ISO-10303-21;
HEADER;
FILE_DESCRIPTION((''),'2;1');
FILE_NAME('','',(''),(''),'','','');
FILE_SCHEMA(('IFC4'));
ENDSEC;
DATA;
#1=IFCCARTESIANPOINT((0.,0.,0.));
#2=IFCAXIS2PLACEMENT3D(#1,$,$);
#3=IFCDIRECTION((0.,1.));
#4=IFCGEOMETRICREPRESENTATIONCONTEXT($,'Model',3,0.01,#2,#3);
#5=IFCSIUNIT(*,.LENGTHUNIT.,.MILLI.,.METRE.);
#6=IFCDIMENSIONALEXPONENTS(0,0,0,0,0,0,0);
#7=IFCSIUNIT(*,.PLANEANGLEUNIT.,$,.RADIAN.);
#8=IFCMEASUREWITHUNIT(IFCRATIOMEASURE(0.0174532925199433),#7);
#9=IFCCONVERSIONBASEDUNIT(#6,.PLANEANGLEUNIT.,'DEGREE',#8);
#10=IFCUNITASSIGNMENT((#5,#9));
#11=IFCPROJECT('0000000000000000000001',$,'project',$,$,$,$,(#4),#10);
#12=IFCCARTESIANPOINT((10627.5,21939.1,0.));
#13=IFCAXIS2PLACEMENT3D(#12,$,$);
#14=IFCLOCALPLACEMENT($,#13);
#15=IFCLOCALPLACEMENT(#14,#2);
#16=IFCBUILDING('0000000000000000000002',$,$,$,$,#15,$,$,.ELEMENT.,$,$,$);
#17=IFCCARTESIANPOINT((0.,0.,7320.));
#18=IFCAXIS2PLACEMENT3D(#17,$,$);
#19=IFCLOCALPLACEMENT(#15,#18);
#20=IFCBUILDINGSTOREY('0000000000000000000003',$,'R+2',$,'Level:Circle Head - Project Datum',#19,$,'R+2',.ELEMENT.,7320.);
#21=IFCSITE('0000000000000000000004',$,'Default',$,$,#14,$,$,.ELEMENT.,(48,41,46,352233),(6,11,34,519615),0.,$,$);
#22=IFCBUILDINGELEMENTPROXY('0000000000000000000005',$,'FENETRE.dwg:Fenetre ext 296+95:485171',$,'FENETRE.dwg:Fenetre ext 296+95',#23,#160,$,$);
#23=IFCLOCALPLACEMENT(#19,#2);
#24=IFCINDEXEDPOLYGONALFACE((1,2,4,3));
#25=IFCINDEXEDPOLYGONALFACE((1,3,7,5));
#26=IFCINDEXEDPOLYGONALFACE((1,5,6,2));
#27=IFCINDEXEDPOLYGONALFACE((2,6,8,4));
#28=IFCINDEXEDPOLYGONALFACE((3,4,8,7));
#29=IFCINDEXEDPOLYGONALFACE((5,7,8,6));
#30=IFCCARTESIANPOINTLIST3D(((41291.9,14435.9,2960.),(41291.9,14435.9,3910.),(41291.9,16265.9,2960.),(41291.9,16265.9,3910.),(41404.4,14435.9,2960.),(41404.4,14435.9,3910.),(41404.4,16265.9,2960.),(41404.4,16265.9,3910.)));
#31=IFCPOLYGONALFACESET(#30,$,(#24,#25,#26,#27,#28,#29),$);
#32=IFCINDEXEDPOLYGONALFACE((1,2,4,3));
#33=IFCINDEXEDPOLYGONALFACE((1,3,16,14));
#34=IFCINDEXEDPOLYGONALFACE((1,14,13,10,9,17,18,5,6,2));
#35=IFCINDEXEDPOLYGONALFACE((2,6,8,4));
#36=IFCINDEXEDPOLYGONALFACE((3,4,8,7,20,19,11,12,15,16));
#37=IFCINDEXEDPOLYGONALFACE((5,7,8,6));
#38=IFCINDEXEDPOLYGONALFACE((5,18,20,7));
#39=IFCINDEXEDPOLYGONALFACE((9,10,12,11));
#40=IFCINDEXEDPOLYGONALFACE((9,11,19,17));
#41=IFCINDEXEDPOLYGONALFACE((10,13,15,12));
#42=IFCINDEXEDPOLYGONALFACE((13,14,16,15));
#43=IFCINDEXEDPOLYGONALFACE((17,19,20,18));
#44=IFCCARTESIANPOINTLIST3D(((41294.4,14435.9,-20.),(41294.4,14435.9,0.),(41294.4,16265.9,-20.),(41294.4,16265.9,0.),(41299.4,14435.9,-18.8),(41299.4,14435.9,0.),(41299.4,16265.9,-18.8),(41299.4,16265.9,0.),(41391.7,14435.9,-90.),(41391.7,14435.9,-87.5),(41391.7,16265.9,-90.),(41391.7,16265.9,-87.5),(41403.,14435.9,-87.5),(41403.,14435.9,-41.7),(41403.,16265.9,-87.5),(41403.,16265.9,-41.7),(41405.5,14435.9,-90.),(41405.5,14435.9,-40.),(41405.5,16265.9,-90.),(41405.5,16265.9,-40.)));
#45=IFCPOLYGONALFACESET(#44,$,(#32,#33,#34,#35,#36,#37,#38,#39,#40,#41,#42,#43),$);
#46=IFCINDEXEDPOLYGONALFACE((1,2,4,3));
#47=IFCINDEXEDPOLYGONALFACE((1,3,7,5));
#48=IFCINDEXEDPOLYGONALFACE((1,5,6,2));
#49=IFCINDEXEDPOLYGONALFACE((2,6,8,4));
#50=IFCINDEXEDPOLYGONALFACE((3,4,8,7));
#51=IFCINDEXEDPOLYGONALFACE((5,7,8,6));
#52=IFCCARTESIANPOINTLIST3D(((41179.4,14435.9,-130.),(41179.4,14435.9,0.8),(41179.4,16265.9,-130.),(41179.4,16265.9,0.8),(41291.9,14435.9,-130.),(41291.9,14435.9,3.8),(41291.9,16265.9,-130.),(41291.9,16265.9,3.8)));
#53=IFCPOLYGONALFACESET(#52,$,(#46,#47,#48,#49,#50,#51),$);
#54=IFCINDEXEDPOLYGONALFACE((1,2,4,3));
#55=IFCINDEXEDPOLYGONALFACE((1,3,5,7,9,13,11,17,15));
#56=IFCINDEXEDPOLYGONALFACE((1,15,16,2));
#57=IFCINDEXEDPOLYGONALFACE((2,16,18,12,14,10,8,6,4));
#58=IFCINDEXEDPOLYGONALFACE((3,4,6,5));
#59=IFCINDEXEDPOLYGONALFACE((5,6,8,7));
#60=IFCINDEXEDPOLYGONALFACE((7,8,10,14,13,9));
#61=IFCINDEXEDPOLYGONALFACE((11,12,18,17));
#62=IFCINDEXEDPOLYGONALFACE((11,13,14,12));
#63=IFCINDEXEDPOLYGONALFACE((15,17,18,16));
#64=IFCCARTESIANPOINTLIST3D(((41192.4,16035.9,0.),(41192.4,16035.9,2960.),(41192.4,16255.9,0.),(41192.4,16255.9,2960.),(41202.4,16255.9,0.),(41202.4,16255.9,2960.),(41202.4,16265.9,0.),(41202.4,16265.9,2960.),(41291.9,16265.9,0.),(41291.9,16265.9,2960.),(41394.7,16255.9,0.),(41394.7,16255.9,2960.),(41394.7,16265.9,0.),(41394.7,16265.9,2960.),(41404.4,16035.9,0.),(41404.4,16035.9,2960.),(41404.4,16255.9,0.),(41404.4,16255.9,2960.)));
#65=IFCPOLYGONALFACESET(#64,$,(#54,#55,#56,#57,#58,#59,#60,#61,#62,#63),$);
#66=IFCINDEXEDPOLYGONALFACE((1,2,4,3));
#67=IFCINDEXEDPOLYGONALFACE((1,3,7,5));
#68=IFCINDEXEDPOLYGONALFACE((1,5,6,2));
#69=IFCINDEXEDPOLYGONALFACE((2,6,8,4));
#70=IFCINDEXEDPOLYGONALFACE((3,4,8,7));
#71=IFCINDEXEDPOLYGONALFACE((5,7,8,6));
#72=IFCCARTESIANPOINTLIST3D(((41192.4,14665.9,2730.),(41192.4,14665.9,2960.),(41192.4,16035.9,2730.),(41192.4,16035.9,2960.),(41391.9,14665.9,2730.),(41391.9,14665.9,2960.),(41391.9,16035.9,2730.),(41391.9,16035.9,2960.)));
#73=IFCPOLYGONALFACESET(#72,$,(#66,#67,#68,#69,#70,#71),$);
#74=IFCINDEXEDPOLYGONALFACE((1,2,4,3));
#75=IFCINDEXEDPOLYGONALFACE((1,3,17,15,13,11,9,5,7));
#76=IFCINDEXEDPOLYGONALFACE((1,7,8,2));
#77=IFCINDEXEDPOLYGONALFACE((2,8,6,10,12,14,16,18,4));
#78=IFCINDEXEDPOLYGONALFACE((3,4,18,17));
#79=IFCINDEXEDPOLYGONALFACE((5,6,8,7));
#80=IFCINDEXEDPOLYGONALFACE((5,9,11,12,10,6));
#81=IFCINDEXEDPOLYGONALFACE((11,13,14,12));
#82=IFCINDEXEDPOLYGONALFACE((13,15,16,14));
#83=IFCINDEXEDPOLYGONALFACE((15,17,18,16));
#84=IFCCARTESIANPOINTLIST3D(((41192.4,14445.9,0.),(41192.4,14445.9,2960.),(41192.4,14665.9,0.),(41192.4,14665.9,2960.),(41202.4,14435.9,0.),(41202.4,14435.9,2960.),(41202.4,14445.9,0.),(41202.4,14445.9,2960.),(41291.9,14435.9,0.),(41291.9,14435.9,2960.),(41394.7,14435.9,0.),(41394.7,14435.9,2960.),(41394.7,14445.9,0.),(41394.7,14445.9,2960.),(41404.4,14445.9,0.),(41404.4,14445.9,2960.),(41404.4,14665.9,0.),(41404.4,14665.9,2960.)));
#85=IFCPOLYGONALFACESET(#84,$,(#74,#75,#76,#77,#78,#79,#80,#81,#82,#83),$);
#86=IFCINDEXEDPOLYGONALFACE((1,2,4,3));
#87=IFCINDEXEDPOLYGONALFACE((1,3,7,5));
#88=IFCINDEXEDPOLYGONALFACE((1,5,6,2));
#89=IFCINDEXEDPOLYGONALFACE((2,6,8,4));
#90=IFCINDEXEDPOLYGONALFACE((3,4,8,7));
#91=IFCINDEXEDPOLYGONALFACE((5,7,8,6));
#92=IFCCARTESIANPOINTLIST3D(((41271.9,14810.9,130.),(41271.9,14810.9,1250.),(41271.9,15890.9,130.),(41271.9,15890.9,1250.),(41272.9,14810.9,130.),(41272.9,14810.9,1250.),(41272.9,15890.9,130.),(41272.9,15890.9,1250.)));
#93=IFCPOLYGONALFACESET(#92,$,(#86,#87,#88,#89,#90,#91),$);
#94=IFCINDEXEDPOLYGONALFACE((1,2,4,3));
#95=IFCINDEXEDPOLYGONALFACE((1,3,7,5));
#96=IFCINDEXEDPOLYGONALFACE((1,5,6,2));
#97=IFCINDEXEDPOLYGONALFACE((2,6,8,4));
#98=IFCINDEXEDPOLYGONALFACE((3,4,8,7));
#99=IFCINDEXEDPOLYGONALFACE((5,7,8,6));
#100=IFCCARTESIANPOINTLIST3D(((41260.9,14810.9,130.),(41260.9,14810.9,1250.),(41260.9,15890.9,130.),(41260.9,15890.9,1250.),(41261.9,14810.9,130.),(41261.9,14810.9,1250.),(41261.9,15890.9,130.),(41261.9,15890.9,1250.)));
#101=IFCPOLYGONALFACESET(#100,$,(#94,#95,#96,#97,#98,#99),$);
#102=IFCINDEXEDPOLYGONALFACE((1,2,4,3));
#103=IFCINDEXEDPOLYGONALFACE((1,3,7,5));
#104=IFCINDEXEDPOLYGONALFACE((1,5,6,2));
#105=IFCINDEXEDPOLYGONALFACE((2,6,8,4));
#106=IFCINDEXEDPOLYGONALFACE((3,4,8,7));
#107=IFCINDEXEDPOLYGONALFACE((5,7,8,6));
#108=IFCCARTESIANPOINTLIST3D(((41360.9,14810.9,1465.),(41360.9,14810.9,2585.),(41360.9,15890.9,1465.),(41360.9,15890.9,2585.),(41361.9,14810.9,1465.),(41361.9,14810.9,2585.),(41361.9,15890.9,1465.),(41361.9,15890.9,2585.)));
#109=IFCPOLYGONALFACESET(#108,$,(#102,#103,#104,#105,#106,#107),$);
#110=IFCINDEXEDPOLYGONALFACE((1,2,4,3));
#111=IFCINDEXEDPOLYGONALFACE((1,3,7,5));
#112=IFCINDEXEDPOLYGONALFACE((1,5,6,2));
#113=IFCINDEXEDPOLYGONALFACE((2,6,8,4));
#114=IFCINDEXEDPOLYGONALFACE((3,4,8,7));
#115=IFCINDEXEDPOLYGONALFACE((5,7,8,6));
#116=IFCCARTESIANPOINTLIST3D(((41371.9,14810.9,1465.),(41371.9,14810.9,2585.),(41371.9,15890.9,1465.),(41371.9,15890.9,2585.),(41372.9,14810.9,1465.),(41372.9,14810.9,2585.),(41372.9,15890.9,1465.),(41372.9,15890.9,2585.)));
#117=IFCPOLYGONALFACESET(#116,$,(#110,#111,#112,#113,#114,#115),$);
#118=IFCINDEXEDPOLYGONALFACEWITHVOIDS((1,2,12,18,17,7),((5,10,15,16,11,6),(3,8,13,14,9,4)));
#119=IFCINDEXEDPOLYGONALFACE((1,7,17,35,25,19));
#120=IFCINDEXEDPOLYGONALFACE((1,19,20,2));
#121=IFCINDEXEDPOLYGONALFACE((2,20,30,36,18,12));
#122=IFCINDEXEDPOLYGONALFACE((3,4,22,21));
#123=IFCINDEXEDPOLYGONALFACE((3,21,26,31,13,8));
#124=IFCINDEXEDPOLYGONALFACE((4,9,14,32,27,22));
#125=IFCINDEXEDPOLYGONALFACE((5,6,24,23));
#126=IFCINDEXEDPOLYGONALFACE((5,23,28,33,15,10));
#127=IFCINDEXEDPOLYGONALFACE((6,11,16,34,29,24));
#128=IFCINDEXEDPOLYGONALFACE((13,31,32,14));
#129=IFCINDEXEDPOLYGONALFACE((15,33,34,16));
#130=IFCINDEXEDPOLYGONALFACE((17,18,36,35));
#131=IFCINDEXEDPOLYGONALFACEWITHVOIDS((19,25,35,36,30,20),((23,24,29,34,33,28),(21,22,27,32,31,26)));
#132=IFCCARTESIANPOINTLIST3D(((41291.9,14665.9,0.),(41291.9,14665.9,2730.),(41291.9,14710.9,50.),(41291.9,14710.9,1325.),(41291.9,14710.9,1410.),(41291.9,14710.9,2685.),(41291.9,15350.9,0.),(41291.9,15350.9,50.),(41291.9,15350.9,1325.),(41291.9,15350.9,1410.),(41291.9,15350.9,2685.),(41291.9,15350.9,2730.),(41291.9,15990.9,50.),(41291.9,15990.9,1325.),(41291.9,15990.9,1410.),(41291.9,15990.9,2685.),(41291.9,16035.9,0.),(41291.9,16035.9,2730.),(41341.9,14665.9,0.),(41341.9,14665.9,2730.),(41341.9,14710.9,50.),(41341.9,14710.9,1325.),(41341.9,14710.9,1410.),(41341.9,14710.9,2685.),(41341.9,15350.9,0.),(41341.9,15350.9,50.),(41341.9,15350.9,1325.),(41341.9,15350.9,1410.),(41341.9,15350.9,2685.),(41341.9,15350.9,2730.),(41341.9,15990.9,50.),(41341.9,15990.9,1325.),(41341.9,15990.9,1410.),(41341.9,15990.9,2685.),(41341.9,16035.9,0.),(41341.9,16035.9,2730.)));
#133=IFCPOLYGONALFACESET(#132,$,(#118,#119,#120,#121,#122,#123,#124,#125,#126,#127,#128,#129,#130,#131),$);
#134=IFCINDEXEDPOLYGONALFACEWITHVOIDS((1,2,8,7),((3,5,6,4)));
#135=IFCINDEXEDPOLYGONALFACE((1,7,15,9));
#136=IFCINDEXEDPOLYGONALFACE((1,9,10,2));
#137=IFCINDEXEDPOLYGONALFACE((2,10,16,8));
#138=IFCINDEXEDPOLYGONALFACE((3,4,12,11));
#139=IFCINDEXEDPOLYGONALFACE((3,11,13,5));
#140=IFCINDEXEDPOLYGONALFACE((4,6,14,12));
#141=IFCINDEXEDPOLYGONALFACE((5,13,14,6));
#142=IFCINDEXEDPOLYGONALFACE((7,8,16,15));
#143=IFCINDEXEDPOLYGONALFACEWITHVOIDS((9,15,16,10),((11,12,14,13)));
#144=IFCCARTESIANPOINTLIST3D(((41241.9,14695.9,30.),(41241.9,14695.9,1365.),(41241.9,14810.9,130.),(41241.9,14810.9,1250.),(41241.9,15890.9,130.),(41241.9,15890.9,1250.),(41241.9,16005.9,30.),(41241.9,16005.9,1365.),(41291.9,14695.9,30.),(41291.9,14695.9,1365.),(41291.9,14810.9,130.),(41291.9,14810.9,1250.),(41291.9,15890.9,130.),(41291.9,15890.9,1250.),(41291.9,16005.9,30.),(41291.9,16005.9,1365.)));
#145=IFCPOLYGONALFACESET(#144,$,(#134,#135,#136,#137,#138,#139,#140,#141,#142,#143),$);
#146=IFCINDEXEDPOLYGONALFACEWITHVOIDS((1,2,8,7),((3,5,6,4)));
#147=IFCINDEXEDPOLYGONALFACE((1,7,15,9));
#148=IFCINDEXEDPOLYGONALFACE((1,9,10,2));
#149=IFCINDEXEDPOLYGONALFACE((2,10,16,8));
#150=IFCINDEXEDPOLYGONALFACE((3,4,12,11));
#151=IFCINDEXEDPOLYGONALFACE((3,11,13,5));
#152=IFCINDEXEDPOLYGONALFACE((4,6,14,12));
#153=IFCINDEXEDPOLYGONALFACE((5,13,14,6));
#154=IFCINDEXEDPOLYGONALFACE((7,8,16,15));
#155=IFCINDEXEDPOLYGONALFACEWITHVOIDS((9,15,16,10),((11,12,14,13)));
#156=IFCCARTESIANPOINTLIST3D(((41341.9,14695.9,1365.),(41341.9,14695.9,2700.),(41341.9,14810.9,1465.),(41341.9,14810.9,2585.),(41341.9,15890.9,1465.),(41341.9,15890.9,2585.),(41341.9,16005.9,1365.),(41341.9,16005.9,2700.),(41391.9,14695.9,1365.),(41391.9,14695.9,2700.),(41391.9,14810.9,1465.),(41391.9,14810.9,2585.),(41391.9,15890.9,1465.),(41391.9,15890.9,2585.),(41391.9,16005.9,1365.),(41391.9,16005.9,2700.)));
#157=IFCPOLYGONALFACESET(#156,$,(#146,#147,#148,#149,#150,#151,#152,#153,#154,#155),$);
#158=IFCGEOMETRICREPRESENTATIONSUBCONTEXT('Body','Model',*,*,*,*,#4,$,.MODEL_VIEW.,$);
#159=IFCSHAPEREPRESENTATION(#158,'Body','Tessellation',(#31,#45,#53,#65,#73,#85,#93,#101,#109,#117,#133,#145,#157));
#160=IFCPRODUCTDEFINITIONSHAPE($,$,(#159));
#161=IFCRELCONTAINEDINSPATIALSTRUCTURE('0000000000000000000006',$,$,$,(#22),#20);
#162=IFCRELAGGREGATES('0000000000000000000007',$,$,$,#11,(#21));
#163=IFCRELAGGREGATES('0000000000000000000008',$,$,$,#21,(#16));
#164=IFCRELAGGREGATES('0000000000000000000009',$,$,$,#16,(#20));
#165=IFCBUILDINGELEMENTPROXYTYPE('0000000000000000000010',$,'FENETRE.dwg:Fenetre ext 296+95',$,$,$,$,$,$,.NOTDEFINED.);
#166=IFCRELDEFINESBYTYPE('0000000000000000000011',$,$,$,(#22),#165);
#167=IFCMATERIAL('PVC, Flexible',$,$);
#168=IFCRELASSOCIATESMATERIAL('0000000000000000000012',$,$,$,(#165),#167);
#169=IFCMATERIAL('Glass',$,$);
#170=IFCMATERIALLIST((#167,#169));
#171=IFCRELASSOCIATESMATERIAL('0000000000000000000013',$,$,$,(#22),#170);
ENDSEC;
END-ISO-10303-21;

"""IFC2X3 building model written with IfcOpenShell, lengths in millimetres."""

from ifc_helpers import new_model, entity, si_unit, converted_unit, direction, frame, frame_2d, origin, origin_2d_with_axis, place, context, subcontext, project, spatial, polyline, rectangle, outline, extrude, source, transform, mapped, material, material_list, type_object, type_shapes, element, save


model = new_model("IFC2X3")

# Units and contexts
model_context = context("Model", 3, precision=0.01, world=origin(), true_north=direction((0.0, 1.0)))
body_context = subcontext(model_context, "Body", "Model", "MODEL_VIEW")
ifc_project = project(units=[si_unit("LENGTHUNIT", "METRE", prefix="MILLI"), converted_unit("PLANEANGLEUNIT", "DEGREE", entity("IfcRatioMeasure", 0.0174532925199433), si_unit("PLANEANGLEUNIT", "RADIAN"), dimensions=[0, 0, 0, 0, 0, 0, 0])], contexts=[model_context])

# Site, building, storey
site_placement = place(None, frame((10627.5, 21939.1, 0.0)))
site = spatial("IfcSite", under=ifc_project, at=site_placement, Name="Default", CompositionType="ELEMENT", RefLatitude=(48, 41, 46, 352233), RefLongitude=(6, 11, 34, 519615), RefElevation=0.0)
building_placement = place(site_placement, origin())
building = spatial("IfcBuilding", under=site, at=building_placement, CompositionType="ELEMENT")
storey_placement = place(building_placement, frame((0.0, 0.0, 7320.0)))
storey = spatial("IfcBuildingStorey", under=building, at=storey_placement, Name="R+2", ObjectType="Level:Circle Head - Project Datum", LongName="R+2", CompositionType="ELEMENT", Elevation=7320.0)

# Building element proxy
ifc_material_1 = material(Name="PVC, Flexible")
ifc_material_2 = material(Name="Glass")
ifc_material_list_1 = material_list([ifc_material_1, ifc_material_2])
building_element_proxy_type_1 = type_object("IfcBuildingElementProxyType", Name="FENETRE.dwg:Fenetre ext 296+95", PredefinedType="NOTDEFINED", material=ifc_material_1)
shared_shape_1 = source(origin(), body_context, "Body", "SweptSolid", [
    extrude(rectangle(XDim=112.5, YDim=1830.0, at=origin_2d_with_axis()), frame((-10.4, -56.3, 2960.0), z_axis=(0.0, 0.0, 1.0), x_axis=(0.0, 1.0, 0.0)), (0.0, 0.0, 1.0), 950.0),
    extrude(outline(polyline([(27.5, -64.4), (47.5, -64.4), (47.5, -59.4), (28.8, -59.4), (7.5, 46.7), (-42.5, 46.7), (-42.5, 32.9), (-40.0, 32.9), (-40.0, 44.2), (5.8, 44.2), (27.5, -64.4)])), frame((-925.4, -66.9, -47.5), z_axis=(1.0, 0.0, 0.0), x_axis=(0.0, 0.0, 1.0)), (0.0, 0.0, 1.0), 1830.0),
    extrude(outline(polyline([(-54.5, -66.1), (58.0, -66.1), (54.5, 67.6), (-58.0, 64.6), (-54.5, -66.1)])), frame((-925.4, 56.3, -63.8), z_axis=(1.0, 0.0, 0.0), x_axis=(0.0, -0.999645, 0.02665)), (0.0, 0.0, 1.0), 1830.0),
    extrude(outline(polyline([(-97.0, -55.6), (5.9, -55.6), (95.4, -55.6), (95.4, -45.6), (105.4, -45.6), (105.4, 174.4), (-106.6, 174.4), (-106.6, -45.6), (-97.0, -45.6), (-97.0, -55.6)])), frame((849.0, -5.9, 0.0), z_axis=(0.0, 0.0, 1.0), x_axis=(0.0, 1.0, 0.0)), (0.0, 0.0, 1.0), 2960.0),
    extrude(rectangle(XDim=1370.0, YDim=199.5, at=origin_2d_with_axis()), frame((-10.4, -0.3, 2730.0), z_axis=(0.0, 0.0, 1.0), x_axis=(-1.0, 0.0, 0.0)), (0.0, 0.0, 1.0), 230.0),
    extrude(outline(polyline([(-55.6, 97.0), (-55.6, -5.9), (-55.6, -95.4), (-45.6, -95.4), (-45.6, -105.4), (174.4, -105.4), (174.4, 106.6), (-45.6, 106.6), (-45.6, 97.0), (-55.6, 97.0)])), frame((-869.9, -5.9, 0.0), z_axis=(0.0, 0.0, -1.0), x_axis=(1.0, 0.0, 0.0)), (0.0, 0.0, -1.0), 2960.0),
    extrude(rectangle(XDim=1080.0, YDim=1.0, at=origin_2d_with_axis()), frame((-10.4, 19.5, 130.0), z_axis=(0.0, 0.0, 1.0), x_axis=(-1.0, 0.0, 0.0)), (0.0, 0.0, 1.0), 1120.0),
    extrude(rectangle(XDim=1080.0, YDim=1.0, at=origin_2d_with_axis()), frame((-10.4, 30.5, 130.0), z_axis=(0.0, 0.0, 1.0), x_axis=(-1.0, 0.0, 0.0)), (0.0, 0.0, 1.0), 1120.0),
    extrude(rectangle(XDim=1080.0, YDim=1.0, at=frame_2d((0.0, 0.0), x_axis=(1.0, 0.0))), frame((-10.4, -69.5, 1465.0), z_axis=(0.0, 0.0, 1.0), x_axis=(-1.0, 0.0, 0.0)), (0.0, 0.0, 1.0), 1120.0),
    extrude(rectangle(XDim=1080.0, YDim=1.0, at=frame_2d((0.0, 0.0), x_axis=(1.0, 0.0))), frame((-10.4, -80.5, 1465.0), z_axis=(0.0, 0.0, 1.0), x_axis=(-1.0, 0.0, 0.0)), (0.0, 0.0, 1.0), 1120.0),
    extrude(outline(polyline([(-685.0, -1365.0), (0.0, -1365.0), (685.0, -1365.0), (685.0, 1365.0), (0.0, 1365.0), (-685.0, 1365.0), (-685.0, -1365.0)]), holes=[polyline([(-640.0, -1320.0), (-640.0, -45.0), (0.0, -45.0), (640.0, -45.0), (640.0, -1320.0), (0.0, -1320.0), (-640.0, -1320.0)]), polyline([(-640.0, 40.0), (-640.0, 1315.0), (0.0, 1315.0), (640.0, 1315.0), (640.0, 40.0), (0.0, 40.0), (-640.0, 40.0)])]), frame((-10.4, -50.0, 1365.0), z_axis=(0.0, 1.0, 0.0), x_axis=(1.0, 0.0, 0.0)), (0.0, 0.0, 1.0), 50.0),
    extrude(outline(polyline([(-655.0, -667.5), (655.0, -667.5), (655.0, 667.5), (-655.0, 667.5), (-655.0, -667.5)]), holes=[polyline([(-540.0, 552.5), (540.0, 552.5), (540.0, -567.5), (-540.0, -567.5), (-540.0, 552.5)])]), frame((-10.4, 0.0, 697.5), z_axis=(0.0, 1.0, 0.0), x_axis=(-1.0, 0.0, 0.0)), (0.0, 0.0, 1.0), 50.0),
    extrude(outline(polyline([(-655.0, -667.5), (655.0, -667.5), (655.0, 667.5), (-655.0, 667.5), (-655.0, -667.5)]), holes=[polyline([(-540.0, 552.5), (540.0, 552.5), (540.0, -567.5), (-540.0, -567.5), (-540.0, 552.5)])]), frame((-10.4, -100.0, 2032.5), z_axis=(0.0, 1.0, 0.0), x_axis=(-1.0, 0.0, 0.0)), (0.0, 0.0, 1.0), 50.0),
])
type_shapes(building_element_proxy_type_1, [shared_shape_1])
proxy_1_placement = place(storey_placement, frame((41291.9, 15361.3, 0.0), z_axis=(0.0, 0.0, 1.0), x_axis=(0.0, 1.0, 0.0)))
element("IfcBuildingElementProxy", 1, at=proxy_1_placement, inside=storey, type_object=building_element_proxy_type_1, material=ifc_material_list_1, Name="FENETRE.dwg:Fenetre ext 296+95:485171", ObjectType="FENETRE.dwg:Fenetre ext 296+95", context=body_context, shape_type="MappedRepresentation", body=[
    mapped(shared_shape_1, transform((0.0, 0.0, 0.0), scale=1.0)),
])

save(model, "model.ifc")
